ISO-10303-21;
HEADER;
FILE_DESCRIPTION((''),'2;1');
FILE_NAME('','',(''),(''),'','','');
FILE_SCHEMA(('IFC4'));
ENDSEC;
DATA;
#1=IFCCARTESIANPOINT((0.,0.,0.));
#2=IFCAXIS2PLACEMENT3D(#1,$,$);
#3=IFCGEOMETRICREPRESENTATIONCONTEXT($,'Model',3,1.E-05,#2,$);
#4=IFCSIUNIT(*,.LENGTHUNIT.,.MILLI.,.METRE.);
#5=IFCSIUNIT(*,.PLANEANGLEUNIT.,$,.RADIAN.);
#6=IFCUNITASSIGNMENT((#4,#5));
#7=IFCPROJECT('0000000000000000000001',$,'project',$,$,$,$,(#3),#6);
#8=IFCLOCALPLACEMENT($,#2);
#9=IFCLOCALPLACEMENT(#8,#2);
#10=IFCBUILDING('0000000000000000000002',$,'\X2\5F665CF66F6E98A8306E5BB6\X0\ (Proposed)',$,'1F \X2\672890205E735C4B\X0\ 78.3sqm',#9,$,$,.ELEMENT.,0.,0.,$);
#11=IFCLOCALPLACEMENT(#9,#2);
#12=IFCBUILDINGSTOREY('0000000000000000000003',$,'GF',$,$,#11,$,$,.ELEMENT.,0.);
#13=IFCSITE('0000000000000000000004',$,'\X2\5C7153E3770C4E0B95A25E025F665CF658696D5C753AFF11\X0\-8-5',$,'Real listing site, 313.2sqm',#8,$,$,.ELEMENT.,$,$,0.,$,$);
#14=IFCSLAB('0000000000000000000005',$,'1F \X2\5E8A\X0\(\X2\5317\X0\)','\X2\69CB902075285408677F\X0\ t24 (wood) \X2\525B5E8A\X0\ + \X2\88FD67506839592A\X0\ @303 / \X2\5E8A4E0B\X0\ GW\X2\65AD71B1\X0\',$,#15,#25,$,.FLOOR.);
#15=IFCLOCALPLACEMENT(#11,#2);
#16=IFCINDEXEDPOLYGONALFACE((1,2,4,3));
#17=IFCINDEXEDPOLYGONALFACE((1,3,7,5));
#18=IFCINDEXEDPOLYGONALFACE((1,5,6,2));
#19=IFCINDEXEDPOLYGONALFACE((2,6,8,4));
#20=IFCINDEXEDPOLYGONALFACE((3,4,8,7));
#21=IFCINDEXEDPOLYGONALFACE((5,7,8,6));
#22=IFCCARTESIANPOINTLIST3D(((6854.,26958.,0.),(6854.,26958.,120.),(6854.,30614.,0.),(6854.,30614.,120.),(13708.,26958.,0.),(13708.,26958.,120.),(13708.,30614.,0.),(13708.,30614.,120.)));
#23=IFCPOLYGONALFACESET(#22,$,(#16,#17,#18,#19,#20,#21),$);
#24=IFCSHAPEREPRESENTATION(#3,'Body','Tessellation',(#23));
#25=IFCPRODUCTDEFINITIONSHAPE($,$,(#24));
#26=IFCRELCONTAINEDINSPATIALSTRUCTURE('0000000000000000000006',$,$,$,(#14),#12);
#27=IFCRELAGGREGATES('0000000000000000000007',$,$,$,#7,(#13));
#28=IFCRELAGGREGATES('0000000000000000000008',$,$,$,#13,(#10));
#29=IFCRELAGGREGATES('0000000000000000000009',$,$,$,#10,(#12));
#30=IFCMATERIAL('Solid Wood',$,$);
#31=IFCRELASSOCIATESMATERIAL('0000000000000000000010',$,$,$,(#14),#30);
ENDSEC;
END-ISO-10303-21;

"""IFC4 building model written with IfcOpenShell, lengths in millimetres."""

from ifc_helpers import new_model, si_unit, frame, frame_2d, origin, place, context, project, spatial, rectangle, extrude, material, element, save


model = new_model("IFC4")

# Units and contexts
model_context = context("Model", 3, precision=1e-05, world=origin())
ifc_project = project(units=[si_unit("LENGTHUNIT", "METRE", prefix="MILLI"), si_unit("PLANEANGLEUNIT", "RADIAN")], contexts=[model_context])

# Site, building, storey
site_placement = place(None, origin())
site = spatial("IfcSite", under=ifc_project, at=site_placement, Name="山口県下関市彦島塩浜町１-8-5", ObjectType="Real listing site, 313.2sqm", CompositionType="ELEMENT", RefElevation=0.0)
building_placement = place(site_placement, origin())
building = spatial("IfcBuilding", under=site, at=building_placement, Name="彦島潮風の家 (Proposed)", ObjectType="1F 木造平屋 78.3sqm", CompositionType="ELEMENT", ElevationOfRefHeight=0.0, ElevationOfTerrain=0.0)
storey_placement = place(building_placement, origin())
storey = spatial("IfcBuildingStorey", under=building, at=storey_placement, Name="GF", CompositionType="ELEMENT", Elevation=0.0)

# Slab
ifc_material_1 = material(Name="Solid Wood")
slab_1_placement = place(storey_placement, frame((3427.0, 13479.0, 0.0)))
element("IfcSlab", 1, at=slab_1_placement, inside=storey, material=ifc_material_1, Name="1F 床(北)", Description="構造用合板 t24 (wood) 剛床 + 製材根太 @303 / 床下 GW断熱", PredefinedType="FLOOR", context=model_context, shape_type="SweptSolid", body=[
    extrude(rectangle(XDim=6854.0, YDim=3656.0, at=frame_2d((3427.0, 1828.0))), frame((3427.0, 13479.0, 0.0)), (0.0, 0.0, 1.0), 120.0),
])

save(model, "model.ifc")
